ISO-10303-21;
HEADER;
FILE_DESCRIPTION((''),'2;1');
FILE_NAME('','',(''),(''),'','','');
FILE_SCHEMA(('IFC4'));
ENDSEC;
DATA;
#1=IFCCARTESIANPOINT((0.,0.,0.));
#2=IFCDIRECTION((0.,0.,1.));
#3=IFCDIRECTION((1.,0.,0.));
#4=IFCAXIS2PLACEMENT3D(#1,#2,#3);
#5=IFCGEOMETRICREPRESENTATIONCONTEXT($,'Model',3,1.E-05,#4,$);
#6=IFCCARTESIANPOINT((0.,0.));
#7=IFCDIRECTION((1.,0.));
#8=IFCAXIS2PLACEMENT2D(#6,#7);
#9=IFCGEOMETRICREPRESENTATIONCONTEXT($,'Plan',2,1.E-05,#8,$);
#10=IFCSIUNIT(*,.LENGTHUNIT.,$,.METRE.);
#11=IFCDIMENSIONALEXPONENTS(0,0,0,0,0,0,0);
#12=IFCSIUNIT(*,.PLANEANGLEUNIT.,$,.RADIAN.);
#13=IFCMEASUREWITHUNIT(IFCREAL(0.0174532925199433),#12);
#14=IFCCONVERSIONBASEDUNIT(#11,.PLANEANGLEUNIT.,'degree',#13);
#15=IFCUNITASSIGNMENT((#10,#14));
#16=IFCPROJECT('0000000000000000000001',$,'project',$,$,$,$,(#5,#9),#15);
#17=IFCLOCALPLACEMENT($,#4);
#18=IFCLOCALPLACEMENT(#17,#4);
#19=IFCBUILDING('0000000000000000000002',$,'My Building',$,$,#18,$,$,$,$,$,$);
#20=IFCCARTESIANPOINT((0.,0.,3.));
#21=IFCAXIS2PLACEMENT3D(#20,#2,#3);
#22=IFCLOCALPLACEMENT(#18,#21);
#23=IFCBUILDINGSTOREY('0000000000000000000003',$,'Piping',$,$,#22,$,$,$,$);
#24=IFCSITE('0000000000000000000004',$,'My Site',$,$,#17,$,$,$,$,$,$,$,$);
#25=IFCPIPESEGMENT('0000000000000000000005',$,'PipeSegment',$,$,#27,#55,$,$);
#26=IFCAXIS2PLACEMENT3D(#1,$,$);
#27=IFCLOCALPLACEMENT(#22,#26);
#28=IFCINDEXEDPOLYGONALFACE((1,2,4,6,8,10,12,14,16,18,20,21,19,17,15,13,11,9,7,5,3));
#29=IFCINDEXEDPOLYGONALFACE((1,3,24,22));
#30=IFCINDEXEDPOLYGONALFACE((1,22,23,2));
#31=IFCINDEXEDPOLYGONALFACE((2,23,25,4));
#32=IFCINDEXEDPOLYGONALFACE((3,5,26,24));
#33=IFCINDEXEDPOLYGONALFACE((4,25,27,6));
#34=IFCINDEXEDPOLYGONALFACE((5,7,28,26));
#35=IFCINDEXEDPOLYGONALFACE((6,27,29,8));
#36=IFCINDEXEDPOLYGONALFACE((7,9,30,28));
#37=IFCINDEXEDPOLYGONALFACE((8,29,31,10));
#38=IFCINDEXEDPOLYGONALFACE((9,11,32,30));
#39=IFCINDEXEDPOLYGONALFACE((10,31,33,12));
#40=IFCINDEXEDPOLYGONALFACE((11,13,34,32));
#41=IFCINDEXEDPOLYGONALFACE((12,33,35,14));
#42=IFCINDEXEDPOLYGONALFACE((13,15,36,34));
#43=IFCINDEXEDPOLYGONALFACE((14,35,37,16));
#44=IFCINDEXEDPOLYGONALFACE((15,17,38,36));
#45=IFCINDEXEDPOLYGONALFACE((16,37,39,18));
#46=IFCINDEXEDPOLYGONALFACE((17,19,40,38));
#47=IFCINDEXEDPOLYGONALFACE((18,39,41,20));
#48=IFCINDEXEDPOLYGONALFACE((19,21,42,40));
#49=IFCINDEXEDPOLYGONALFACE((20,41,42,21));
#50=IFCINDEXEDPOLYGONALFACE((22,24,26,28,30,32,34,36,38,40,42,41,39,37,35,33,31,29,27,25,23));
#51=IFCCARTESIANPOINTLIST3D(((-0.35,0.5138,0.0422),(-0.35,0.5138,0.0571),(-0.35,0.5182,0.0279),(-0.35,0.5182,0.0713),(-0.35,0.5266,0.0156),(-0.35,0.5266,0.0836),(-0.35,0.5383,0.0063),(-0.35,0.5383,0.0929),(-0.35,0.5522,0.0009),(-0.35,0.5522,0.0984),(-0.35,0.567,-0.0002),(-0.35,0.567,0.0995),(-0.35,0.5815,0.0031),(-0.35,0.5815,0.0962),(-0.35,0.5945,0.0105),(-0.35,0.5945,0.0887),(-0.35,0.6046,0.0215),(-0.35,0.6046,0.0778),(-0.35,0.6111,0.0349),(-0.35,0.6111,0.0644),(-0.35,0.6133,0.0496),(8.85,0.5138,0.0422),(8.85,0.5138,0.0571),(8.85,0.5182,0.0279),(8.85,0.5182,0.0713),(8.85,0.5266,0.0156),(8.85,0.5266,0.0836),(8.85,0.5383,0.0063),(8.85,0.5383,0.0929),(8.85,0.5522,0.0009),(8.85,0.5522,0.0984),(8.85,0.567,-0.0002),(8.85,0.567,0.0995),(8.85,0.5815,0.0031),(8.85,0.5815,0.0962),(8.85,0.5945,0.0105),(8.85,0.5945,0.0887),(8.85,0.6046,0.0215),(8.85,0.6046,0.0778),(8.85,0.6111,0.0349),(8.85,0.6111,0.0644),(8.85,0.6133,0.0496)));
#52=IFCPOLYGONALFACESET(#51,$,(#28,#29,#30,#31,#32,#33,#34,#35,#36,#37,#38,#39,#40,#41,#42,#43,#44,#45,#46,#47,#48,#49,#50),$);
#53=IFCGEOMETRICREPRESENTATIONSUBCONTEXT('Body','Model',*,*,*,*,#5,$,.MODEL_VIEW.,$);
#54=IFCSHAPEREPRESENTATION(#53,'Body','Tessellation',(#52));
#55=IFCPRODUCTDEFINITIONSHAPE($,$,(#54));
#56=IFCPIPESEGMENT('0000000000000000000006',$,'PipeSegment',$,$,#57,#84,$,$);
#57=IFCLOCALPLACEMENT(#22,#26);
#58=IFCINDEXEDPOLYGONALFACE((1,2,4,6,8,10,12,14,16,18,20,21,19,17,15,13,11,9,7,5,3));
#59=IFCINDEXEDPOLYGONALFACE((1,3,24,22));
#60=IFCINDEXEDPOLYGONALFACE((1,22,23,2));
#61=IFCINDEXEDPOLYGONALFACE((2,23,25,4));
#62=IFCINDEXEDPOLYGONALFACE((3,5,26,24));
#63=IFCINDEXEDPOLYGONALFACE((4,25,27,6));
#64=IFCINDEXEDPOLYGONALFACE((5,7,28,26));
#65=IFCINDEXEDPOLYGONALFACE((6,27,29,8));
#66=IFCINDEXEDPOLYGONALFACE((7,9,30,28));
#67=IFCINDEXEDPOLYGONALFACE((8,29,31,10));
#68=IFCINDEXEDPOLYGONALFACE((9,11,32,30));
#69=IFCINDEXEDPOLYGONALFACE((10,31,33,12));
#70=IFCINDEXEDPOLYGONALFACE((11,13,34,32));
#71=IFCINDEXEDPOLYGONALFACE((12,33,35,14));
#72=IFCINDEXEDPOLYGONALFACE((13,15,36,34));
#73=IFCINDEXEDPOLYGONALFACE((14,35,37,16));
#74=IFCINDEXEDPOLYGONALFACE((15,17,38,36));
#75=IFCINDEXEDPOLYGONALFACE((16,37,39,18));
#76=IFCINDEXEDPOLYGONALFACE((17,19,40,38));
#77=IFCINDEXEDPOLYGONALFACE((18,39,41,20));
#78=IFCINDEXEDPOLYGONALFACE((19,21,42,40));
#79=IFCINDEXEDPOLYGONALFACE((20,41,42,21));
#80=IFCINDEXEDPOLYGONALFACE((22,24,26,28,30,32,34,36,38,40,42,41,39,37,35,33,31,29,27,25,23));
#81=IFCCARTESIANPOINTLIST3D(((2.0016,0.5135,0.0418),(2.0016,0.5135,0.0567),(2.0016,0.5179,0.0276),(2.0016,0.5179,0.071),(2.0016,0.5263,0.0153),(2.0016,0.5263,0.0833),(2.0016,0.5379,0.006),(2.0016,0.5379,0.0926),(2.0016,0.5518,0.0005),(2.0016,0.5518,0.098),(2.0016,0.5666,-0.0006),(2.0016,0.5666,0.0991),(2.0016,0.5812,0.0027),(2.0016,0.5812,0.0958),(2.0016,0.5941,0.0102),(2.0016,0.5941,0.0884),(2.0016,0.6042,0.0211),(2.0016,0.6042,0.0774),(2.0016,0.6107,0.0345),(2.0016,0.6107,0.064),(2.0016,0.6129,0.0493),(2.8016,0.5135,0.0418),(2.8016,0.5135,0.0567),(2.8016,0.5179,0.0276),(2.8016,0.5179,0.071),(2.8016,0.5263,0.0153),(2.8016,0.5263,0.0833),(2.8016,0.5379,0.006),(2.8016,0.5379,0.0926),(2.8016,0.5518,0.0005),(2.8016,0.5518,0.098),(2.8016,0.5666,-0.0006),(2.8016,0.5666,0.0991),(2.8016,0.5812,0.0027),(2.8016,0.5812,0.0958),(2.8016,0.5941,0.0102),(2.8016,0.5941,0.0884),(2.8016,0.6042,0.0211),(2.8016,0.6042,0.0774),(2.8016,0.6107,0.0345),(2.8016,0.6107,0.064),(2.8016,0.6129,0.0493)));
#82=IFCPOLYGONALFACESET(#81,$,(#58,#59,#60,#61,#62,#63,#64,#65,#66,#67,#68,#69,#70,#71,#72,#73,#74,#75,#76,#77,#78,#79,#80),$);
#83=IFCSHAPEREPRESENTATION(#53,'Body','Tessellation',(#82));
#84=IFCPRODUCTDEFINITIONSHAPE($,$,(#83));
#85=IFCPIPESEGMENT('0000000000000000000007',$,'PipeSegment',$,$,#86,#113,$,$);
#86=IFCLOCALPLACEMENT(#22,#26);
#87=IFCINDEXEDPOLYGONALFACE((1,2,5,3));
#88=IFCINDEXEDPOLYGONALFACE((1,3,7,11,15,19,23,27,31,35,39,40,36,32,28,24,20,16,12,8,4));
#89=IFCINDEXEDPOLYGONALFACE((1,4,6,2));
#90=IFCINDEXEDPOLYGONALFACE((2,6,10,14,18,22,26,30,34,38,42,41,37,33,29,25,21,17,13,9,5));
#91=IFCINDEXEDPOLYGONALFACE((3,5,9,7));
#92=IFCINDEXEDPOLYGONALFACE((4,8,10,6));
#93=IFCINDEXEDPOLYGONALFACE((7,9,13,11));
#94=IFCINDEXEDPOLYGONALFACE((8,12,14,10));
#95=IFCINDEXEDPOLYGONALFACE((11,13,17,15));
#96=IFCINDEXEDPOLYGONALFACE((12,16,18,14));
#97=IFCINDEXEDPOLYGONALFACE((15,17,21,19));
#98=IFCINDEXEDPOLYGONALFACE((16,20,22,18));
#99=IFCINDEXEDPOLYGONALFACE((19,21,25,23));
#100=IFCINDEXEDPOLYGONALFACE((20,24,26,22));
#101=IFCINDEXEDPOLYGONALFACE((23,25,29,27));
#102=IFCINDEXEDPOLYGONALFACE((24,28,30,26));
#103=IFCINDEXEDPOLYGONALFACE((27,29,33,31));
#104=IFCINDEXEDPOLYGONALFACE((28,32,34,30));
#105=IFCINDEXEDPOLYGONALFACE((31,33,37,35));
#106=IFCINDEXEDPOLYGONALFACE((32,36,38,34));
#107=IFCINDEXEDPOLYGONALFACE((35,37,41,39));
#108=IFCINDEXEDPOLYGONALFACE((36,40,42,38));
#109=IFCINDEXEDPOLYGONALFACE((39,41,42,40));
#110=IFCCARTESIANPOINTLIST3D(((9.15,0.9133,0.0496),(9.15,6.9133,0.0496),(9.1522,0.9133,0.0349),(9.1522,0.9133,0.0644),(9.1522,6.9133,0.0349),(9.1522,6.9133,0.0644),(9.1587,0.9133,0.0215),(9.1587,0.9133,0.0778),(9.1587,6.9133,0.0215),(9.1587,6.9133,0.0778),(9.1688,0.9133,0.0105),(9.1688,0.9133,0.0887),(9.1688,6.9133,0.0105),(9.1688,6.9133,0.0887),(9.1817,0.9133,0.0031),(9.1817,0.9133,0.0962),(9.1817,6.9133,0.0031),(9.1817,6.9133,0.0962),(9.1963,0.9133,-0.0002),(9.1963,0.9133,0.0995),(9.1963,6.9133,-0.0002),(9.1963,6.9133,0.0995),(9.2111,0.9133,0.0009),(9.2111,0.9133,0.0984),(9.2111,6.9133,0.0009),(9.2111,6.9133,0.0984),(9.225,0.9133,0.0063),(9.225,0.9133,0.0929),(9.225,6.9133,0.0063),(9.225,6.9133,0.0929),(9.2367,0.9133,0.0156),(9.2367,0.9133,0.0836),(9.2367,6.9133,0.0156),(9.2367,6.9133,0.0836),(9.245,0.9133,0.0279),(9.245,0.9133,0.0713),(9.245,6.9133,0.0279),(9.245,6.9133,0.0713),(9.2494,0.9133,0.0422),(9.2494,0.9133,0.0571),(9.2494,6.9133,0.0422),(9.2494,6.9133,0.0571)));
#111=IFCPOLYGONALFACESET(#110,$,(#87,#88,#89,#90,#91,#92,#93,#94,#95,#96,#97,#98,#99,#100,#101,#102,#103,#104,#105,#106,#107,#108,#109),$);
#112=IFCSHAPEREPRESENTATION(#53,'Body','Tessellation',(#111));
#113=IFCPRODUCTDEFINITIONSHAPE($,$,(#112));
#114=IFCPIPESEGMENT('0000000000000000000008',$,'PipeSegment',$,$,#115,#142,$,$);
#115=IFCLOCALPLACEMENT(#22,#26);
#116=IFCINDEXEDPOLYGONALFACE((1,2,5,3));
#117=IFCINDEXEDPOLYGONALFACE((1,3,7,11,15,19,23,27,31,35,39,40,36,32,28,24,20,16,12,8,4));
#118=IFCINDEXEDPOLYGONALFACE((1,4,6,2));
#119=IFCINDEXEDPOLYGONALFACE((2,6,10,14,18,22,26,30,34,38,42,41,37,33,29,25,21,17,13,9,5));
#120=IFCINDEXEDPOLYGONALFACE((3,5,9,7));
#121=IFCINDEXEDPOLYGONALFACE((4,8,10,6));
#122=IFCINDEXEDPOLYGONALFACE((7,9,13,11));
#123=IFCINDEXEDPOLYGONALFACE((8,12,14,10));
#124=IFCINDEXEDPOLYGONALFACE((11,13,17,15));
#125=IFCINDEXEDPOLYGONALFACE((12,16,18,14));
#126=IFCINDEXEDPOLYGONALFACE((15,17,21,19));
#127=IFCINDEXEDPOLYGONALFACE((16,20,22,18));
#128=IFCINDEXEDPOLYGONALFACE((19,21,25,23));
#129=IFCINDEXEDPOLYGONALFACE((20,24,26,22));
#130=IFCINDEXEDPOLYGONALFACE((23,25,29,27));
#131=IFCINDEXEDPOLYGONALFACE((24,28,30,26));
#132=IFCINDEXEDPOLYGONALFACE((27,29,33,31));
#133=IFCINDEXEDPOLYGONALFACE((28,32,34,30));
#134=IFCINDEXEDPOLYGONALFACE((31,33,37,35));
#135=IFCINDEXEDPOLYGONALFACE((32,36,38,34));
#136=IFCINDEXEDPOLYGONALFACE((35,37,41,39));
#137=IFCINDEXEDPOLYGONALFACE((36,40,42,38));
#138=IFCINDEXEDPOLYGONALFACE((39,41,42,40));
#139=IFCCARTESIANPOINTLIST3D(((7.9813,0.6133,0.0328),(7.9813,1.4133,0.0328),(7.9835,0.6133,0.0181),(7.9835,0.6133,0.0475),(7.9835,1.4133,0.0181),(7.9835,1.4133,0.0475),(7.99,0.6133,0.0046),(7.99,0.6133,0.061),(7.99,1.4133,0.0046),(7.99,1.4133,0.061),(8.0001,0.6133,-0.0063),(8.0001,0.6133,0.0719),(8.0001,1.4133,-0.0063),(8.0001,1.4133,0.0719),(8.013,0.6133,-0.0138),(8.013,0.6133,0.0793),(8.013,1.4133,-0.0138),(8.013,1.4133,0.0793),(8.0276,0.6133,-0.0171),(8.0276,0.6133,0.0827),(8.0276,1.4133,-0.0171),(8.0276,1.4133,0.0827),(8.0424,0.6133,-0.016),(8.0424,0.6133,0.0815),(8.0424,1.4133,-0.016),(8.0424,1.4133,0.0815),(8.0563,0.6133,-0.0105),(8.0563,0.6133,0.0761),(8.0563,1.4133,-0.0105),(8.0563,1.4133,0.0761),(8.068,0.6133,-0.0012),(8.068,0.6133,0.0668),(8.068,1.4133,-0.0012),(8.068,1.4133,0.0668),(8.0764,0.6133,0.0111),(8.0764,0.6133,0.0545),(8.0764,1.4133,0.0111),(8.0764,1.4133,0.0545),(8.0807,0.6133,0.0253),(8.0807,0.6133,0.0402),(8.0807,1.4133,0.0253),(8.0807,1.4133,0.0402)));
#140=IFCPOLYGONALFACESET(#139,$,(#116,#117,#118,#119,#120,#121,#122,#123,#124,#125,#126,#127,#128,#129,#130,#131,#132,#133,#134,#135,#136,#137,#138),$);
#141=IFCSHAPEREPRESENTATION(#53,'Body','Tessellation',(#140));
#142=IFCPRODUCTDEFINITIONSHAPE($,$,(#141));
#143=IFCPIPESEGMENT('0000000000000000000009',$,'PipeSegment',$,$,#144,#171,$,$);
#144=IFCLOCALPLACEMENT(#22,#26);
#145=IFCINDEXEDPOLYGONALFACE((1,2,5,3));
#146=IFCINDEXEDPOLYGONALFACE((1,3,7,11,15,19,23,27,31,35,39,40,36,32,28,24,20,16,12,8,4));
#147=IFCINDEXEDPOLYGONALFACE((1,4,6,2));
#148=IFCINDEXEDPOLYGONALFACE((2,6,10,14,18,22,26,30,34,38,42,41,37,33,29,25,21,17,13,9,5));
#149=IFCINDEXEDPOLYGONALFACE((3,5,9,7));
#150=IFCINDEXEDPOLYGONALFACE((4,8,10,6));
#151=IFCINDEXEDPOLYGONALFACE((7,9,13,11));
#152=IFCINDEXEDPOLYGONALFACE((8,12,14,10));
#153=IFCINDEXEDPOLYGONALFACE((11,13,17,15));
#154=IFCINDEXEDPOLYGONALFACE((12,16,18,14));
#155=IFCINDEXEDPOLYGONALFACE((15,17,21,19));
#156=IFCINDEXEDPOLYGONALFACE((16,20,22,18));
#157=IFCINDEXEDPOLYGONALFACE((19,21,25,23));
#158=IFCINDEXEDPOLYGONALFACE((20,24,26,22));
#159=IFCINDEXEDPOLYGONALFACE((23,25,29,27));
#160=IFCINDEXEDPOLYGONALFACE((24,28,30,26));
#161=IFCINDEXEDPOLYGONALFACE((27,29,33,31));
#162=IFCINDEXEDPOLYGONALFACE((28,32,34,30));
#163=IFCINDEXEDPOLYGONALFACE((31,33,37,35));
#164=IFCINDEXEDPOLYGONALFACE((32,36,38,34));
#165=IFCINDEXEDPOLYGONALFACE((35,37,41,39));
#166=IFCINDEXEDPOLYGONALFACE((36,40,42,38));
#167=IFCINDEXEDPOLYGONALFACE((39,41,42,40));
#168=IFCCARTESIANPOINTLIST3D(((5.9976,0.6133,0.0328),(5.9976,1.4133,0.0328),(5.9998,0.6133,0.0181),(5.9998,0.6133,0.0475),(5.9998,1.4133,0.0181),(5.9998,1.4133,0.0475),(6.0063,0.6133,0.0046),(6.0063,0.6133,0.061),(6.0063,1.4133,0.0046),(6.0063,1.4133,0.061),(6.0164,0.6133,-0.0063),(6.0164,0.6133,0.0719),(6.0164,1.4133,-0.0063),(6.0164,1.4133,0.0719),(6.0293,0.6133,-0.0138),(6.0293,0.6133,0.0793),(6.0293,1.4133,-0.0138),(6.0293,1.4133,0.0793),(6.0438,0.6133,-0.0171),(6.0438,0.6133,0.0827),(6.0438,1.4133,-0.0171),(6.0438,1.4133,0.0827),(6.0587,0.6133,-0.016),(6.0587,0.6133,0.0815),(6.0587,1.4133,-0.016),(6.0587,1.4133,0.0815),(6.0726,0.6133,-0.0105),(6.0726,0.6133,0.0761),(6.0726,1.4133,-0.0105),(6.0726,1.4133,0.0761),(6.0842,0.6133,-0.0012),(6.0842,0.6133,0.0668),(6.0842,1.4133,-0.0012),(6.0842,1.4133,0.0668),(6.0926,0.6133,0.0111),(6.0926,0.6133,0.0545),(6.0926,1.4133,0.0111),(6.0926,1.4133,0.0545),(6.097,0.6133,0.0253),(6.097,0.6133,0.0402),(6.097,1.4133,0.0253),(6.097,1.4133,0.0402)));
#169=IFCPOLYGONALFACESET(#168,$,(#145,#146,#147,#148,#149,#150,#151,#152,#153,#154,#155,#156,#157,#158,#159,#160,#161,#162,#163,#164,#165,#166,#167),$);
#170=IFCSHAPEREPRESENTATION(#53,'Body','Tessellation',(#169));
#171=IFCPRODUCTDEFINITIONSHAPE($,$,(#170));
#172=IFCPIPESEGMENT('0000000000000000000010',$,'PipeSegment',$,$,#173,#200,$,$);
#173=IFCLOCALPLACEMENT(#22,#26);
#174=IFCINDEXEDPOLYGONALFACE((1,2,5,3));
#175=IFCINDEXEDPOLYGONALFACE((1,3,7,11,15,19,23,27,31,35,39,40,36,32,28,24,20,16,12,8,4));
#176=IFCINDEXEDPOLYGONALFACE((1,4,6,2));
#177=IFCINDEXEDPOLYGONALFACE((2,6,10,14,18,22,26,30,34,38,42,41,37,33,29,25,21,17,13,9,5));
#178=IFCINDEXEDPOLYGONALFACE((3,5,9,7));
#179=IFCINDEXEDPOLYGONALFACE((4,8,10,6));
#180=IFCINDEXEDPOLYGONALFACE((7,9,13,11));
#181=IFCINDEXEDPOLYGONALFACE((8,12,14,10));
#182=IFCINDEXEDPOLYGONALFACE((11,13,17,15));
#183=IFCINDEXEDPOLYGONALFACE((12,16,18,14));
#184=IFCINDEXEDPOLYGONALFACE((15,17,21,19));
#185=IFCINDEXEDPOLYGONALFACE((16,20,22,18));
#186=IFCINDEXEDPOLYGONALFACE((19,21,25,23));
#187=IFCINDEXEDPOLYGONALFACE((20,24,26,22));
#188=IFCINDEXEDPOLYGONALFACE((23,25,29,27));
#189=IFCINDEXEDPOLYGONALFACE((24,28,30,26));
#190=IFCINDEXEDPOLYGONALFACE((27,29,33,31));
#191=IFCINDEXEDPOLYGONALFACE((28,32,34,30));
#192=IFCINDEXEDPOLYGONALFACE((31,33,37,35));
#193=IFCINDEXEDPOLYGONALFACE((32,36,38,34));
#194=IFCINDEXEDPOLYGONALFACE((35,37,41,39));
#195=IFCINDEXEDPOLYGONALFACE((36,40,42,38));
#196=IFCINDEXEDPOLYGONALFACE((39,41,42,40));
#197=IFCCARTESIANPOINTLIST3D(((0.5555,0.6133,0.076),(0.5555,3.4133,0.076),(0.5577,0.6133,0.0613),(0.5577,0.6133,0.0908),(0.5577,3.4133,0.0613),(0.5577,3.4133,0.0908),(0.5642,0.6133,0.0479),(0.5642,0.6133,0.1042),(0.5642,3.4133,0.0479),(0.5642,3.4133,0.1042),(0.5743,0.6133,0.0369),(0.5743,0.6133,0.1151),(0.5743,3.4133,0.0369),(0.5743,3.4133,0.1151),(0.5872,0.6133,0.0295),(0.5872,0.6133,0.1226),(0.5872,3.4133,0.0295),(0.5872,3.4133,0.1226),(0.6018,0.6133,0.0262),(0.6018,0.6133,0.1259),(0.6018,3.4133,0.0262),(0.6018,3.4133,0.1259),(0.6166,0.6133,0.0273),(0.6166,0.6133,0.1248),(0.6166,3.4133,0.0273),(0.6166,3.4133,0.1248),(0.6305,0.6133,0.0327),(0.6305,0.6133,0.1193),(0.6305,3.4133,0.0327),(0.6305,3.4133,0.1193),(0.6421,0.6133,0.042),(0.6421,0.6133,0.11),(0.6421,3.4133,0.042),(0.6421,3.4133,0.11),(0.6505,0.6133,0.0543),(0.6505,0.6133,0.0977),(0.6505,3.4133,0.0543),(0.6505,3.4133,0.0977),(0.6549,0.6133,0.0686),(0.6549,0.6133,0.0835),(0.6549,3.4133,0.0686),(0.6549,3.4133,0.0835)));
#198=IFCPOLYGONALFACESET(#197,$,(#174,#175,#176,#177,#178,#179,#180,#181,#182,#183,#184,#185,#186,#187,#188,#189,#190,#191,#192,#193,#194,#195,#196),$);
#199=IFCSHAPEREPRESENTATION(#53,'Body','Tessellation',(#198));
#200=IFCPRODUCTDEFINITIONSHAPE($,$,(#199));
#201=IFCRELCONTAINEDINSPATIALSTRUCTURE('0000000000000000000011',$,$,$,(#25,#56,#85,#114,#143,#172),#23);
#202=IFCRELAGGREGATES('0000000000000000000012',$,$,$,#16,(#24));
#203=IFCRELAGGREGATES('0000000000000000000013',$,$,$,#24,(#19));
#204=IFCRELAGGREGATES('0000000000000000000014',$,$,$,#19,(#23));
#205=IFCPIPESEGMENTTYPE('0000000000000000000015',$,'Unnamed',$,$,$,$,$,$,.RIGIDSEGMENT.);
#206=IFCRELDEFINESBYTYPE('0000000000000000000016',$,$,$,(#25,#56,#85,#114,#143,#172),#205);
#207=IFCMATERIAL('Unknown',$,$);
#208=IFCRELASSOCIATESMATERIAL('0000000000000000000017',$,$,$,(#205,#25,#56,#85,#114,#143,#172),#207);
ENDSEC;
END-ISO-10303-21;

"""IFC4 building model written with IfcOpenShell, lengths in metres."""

from ifc_helpers import new_model, entity, si_unit, converted_unit, frame, origin_with_axes, origin_2d_with_axis, place, context, subcontext, project, spatial, circle, extrude, material, material_profile, profile_set, profile_usage, type_object, element, save


model = new_model("IFC4")

# Units and contexts
model_context = context("Model", 3, precision=1e-05, world=origin_with_axes())
plan_context = context("Plan", 2, precision=1e-05, world=origin_2d_with_axis())
body_context = subcontext(model_context, "Body", "Model", "MODEL_VIEW")
ifc_project = project(units=[si_unit("LENGTHUNIT", "METRE"), converted_unit("PLANEANGLEUNIT", "degree", entity("IfcReal", 0.0174532925199433), si_unit("PLANEANGLEUNIT", "RADIAN"), dimensions=[0, 0, 0, 0, 0, 0, 0])], contexts=[model_context, plan_context])

# Site, building, storey
site_placement = place(None, origin_with_axes())
site = spatial("IfcSite", under=ifc_project, at=site_placement, Name="My Site")
building_placement = place(site_placement, origin_with_axes())
building = spatial("IfcBuilding", under=site, at=building_placement, Name="My Building")
storey_placement = place(building_placement, frame((0.0, 0.0, 3.0), z_axis=(0.0, 0.0, 1.0), x_axis=(1.0, 0.0, 0.0)))
storey = spatial("IfcBuildingStorey", under=building, at=storey_placement, Name="Piping")

# Pipe segments
ifc_material = material(Name="Unknown")
ifc_material_profile = material_profile(ifc_material, circle(Radius=0.05))
ifc_profile_set = profile_set([ifc_material_profile])
ifc_profile_usage_1 = profile_usage(ifc_profile_set, cardinal=5)
pipe_segment_type = type_object("IfcPipeSegmentType", Name="Unnamed", PredefinedType="RIGIDSEGMENT", material=ifc_profile_set)
pipe_segment_1_placement = place(storey_placement, frame((-0.35, 0.5633, 0.0496), z_axis=(1.0, 0.0, 0.0), x_axis=(0.0, 1.0, 0.0)))
element("IfcPipeSegment", 1, at=pipe_segment_1_placement, inside=storey, type_object=pipe_segment_type, material=ifc_profile_usage_1, Name="PipeSegment", context=body_context, shape_type="SweptSolid", body=[
    extrude(circle(Radius=0.05), origin_with_axes(), (0.0, 0.0, 1.0), 9.2),
])
ifc_profile_usage_2 = profile_usage(ifc_profile_set, cardinal=8)
pipe_segment_2_placement = place(storey_placement, frame((2.0016, 0.5629, 0.0993), z_axis=(1.0, 0.0, 0.0), x_axis=(0.0, 1.0, 0.0)))
element("IfcPipeSegment", 2, at=pipe_segment_2_placement, inside=storey, type_object=pipe_segment_type, material=ifc_profile_usage_2, Name="PipeSegment", context=body_context, shape_type="SweptSolid", body=[
    extrude(circle(Radius=0.05), frame((0.0, -0.05, 0.0), z_axis=(0.0, 0.0, 1.0), x_axis=(1.0, 0.0, 0.0)), (0.0, 0.0, 1.0), 0.8),
])
ifc_profile_usage_3 = profile_usage(ifc_profile_set, cardinal=10)
pipe_segment_3_placement = place(storey_placement, frame((9.2, 0.9133, 0.0496), z_axis=(0.0, 1.0, 0.0), x_axis=(-1.0, 0.0, 0.0)))
element("IfcPipeSegment", 3, at=pipe_segment_3_placement, inside=storey, type_object=pipe_segment_type, material=ifc_profile_usage_3, Name="PipeSegment", context=body_context, shape_type="SweptSolid", body=[
    extrude(circle(Radius=0.05), origin_with_axes(), (0.0, 0.0, 1.0), 6.0),
])
ifc_profile_usage_4 = profile_usage(ifc_profile_set, cardinal=8)
pipe_segment_4_placement = place(storey_placement, frame((8.0313, 0.6133, 0.0828), z_axis=(0.0, 1.0, 0.0), x_axis=(-1.0, 0.0, 0.0)))
element("IfcPipeSegment", 4, at=pipe_segment_4_placement, inside=storey, type_object=pipe_segment_type, material=ifc_profile_usage_4, Name="PipeSegment", context=body_context, shape_type="SweptSolid", body=[
    extrude(circle(Radius=0.05), frame((0.0, -0.05, 0.0), z_axis=(0.0, 0.0, 1.0), x_axis=(1.0, 0.0, 0.0)), (0.0, 0.0, 1.0), 0.8),
])
ifc_profile_usage_5 = profile_usage(ifc_profile_set, cardinal=8)
pipe_segment_5_placement = place(storey_placement, frame((6.0476, 0.6133, 0.0828), z_axis=(0.0, 1.0, 0.0), x_axis=(-1.0, 0.0, 0.0)))
element("IfcPipeSegment", 5, at=pipe_segment_5_placement, inside=storey, type_object=pipe_segment_type, material=ifc_profile_usage_5, Name="PipeSegment", context=body_context, shape_type="SweptSolid", body=[
    extrude(circle(Radius=0.05), frame((0.0, -0.05, 0.0), z_axis=(0.0, 0.0, 1.0), x_axis=(1.0, 0.0, 0.0)), (0.0, 0.0, 1.0), 0.8),
])
ifc_profile_usage_6 = profile_usage(ifc_profile_set, cardinal=10)
pipe_segment_6_placement = place(storey_placement, frame((0.6055, 0.6133, 0.076), z_axis=(0.0, 1.0, 0.0), x_axis=(-1.0, 0.0, 0.0)))
element("IfcPipeSegment", 6, at=pipe_segment_6_placement, inside=storey, type_object=pipe_segment_type, material=ifc_profile_usage_6, Name="PipeSegment", context=body_context, shape_type="SweptSolid", body=[
    extrude(circle(Radius=0.05), origin_with_axes(), (0.0, 0.0, 1.0), 2.8),
])

save(model, "model.ifc")
